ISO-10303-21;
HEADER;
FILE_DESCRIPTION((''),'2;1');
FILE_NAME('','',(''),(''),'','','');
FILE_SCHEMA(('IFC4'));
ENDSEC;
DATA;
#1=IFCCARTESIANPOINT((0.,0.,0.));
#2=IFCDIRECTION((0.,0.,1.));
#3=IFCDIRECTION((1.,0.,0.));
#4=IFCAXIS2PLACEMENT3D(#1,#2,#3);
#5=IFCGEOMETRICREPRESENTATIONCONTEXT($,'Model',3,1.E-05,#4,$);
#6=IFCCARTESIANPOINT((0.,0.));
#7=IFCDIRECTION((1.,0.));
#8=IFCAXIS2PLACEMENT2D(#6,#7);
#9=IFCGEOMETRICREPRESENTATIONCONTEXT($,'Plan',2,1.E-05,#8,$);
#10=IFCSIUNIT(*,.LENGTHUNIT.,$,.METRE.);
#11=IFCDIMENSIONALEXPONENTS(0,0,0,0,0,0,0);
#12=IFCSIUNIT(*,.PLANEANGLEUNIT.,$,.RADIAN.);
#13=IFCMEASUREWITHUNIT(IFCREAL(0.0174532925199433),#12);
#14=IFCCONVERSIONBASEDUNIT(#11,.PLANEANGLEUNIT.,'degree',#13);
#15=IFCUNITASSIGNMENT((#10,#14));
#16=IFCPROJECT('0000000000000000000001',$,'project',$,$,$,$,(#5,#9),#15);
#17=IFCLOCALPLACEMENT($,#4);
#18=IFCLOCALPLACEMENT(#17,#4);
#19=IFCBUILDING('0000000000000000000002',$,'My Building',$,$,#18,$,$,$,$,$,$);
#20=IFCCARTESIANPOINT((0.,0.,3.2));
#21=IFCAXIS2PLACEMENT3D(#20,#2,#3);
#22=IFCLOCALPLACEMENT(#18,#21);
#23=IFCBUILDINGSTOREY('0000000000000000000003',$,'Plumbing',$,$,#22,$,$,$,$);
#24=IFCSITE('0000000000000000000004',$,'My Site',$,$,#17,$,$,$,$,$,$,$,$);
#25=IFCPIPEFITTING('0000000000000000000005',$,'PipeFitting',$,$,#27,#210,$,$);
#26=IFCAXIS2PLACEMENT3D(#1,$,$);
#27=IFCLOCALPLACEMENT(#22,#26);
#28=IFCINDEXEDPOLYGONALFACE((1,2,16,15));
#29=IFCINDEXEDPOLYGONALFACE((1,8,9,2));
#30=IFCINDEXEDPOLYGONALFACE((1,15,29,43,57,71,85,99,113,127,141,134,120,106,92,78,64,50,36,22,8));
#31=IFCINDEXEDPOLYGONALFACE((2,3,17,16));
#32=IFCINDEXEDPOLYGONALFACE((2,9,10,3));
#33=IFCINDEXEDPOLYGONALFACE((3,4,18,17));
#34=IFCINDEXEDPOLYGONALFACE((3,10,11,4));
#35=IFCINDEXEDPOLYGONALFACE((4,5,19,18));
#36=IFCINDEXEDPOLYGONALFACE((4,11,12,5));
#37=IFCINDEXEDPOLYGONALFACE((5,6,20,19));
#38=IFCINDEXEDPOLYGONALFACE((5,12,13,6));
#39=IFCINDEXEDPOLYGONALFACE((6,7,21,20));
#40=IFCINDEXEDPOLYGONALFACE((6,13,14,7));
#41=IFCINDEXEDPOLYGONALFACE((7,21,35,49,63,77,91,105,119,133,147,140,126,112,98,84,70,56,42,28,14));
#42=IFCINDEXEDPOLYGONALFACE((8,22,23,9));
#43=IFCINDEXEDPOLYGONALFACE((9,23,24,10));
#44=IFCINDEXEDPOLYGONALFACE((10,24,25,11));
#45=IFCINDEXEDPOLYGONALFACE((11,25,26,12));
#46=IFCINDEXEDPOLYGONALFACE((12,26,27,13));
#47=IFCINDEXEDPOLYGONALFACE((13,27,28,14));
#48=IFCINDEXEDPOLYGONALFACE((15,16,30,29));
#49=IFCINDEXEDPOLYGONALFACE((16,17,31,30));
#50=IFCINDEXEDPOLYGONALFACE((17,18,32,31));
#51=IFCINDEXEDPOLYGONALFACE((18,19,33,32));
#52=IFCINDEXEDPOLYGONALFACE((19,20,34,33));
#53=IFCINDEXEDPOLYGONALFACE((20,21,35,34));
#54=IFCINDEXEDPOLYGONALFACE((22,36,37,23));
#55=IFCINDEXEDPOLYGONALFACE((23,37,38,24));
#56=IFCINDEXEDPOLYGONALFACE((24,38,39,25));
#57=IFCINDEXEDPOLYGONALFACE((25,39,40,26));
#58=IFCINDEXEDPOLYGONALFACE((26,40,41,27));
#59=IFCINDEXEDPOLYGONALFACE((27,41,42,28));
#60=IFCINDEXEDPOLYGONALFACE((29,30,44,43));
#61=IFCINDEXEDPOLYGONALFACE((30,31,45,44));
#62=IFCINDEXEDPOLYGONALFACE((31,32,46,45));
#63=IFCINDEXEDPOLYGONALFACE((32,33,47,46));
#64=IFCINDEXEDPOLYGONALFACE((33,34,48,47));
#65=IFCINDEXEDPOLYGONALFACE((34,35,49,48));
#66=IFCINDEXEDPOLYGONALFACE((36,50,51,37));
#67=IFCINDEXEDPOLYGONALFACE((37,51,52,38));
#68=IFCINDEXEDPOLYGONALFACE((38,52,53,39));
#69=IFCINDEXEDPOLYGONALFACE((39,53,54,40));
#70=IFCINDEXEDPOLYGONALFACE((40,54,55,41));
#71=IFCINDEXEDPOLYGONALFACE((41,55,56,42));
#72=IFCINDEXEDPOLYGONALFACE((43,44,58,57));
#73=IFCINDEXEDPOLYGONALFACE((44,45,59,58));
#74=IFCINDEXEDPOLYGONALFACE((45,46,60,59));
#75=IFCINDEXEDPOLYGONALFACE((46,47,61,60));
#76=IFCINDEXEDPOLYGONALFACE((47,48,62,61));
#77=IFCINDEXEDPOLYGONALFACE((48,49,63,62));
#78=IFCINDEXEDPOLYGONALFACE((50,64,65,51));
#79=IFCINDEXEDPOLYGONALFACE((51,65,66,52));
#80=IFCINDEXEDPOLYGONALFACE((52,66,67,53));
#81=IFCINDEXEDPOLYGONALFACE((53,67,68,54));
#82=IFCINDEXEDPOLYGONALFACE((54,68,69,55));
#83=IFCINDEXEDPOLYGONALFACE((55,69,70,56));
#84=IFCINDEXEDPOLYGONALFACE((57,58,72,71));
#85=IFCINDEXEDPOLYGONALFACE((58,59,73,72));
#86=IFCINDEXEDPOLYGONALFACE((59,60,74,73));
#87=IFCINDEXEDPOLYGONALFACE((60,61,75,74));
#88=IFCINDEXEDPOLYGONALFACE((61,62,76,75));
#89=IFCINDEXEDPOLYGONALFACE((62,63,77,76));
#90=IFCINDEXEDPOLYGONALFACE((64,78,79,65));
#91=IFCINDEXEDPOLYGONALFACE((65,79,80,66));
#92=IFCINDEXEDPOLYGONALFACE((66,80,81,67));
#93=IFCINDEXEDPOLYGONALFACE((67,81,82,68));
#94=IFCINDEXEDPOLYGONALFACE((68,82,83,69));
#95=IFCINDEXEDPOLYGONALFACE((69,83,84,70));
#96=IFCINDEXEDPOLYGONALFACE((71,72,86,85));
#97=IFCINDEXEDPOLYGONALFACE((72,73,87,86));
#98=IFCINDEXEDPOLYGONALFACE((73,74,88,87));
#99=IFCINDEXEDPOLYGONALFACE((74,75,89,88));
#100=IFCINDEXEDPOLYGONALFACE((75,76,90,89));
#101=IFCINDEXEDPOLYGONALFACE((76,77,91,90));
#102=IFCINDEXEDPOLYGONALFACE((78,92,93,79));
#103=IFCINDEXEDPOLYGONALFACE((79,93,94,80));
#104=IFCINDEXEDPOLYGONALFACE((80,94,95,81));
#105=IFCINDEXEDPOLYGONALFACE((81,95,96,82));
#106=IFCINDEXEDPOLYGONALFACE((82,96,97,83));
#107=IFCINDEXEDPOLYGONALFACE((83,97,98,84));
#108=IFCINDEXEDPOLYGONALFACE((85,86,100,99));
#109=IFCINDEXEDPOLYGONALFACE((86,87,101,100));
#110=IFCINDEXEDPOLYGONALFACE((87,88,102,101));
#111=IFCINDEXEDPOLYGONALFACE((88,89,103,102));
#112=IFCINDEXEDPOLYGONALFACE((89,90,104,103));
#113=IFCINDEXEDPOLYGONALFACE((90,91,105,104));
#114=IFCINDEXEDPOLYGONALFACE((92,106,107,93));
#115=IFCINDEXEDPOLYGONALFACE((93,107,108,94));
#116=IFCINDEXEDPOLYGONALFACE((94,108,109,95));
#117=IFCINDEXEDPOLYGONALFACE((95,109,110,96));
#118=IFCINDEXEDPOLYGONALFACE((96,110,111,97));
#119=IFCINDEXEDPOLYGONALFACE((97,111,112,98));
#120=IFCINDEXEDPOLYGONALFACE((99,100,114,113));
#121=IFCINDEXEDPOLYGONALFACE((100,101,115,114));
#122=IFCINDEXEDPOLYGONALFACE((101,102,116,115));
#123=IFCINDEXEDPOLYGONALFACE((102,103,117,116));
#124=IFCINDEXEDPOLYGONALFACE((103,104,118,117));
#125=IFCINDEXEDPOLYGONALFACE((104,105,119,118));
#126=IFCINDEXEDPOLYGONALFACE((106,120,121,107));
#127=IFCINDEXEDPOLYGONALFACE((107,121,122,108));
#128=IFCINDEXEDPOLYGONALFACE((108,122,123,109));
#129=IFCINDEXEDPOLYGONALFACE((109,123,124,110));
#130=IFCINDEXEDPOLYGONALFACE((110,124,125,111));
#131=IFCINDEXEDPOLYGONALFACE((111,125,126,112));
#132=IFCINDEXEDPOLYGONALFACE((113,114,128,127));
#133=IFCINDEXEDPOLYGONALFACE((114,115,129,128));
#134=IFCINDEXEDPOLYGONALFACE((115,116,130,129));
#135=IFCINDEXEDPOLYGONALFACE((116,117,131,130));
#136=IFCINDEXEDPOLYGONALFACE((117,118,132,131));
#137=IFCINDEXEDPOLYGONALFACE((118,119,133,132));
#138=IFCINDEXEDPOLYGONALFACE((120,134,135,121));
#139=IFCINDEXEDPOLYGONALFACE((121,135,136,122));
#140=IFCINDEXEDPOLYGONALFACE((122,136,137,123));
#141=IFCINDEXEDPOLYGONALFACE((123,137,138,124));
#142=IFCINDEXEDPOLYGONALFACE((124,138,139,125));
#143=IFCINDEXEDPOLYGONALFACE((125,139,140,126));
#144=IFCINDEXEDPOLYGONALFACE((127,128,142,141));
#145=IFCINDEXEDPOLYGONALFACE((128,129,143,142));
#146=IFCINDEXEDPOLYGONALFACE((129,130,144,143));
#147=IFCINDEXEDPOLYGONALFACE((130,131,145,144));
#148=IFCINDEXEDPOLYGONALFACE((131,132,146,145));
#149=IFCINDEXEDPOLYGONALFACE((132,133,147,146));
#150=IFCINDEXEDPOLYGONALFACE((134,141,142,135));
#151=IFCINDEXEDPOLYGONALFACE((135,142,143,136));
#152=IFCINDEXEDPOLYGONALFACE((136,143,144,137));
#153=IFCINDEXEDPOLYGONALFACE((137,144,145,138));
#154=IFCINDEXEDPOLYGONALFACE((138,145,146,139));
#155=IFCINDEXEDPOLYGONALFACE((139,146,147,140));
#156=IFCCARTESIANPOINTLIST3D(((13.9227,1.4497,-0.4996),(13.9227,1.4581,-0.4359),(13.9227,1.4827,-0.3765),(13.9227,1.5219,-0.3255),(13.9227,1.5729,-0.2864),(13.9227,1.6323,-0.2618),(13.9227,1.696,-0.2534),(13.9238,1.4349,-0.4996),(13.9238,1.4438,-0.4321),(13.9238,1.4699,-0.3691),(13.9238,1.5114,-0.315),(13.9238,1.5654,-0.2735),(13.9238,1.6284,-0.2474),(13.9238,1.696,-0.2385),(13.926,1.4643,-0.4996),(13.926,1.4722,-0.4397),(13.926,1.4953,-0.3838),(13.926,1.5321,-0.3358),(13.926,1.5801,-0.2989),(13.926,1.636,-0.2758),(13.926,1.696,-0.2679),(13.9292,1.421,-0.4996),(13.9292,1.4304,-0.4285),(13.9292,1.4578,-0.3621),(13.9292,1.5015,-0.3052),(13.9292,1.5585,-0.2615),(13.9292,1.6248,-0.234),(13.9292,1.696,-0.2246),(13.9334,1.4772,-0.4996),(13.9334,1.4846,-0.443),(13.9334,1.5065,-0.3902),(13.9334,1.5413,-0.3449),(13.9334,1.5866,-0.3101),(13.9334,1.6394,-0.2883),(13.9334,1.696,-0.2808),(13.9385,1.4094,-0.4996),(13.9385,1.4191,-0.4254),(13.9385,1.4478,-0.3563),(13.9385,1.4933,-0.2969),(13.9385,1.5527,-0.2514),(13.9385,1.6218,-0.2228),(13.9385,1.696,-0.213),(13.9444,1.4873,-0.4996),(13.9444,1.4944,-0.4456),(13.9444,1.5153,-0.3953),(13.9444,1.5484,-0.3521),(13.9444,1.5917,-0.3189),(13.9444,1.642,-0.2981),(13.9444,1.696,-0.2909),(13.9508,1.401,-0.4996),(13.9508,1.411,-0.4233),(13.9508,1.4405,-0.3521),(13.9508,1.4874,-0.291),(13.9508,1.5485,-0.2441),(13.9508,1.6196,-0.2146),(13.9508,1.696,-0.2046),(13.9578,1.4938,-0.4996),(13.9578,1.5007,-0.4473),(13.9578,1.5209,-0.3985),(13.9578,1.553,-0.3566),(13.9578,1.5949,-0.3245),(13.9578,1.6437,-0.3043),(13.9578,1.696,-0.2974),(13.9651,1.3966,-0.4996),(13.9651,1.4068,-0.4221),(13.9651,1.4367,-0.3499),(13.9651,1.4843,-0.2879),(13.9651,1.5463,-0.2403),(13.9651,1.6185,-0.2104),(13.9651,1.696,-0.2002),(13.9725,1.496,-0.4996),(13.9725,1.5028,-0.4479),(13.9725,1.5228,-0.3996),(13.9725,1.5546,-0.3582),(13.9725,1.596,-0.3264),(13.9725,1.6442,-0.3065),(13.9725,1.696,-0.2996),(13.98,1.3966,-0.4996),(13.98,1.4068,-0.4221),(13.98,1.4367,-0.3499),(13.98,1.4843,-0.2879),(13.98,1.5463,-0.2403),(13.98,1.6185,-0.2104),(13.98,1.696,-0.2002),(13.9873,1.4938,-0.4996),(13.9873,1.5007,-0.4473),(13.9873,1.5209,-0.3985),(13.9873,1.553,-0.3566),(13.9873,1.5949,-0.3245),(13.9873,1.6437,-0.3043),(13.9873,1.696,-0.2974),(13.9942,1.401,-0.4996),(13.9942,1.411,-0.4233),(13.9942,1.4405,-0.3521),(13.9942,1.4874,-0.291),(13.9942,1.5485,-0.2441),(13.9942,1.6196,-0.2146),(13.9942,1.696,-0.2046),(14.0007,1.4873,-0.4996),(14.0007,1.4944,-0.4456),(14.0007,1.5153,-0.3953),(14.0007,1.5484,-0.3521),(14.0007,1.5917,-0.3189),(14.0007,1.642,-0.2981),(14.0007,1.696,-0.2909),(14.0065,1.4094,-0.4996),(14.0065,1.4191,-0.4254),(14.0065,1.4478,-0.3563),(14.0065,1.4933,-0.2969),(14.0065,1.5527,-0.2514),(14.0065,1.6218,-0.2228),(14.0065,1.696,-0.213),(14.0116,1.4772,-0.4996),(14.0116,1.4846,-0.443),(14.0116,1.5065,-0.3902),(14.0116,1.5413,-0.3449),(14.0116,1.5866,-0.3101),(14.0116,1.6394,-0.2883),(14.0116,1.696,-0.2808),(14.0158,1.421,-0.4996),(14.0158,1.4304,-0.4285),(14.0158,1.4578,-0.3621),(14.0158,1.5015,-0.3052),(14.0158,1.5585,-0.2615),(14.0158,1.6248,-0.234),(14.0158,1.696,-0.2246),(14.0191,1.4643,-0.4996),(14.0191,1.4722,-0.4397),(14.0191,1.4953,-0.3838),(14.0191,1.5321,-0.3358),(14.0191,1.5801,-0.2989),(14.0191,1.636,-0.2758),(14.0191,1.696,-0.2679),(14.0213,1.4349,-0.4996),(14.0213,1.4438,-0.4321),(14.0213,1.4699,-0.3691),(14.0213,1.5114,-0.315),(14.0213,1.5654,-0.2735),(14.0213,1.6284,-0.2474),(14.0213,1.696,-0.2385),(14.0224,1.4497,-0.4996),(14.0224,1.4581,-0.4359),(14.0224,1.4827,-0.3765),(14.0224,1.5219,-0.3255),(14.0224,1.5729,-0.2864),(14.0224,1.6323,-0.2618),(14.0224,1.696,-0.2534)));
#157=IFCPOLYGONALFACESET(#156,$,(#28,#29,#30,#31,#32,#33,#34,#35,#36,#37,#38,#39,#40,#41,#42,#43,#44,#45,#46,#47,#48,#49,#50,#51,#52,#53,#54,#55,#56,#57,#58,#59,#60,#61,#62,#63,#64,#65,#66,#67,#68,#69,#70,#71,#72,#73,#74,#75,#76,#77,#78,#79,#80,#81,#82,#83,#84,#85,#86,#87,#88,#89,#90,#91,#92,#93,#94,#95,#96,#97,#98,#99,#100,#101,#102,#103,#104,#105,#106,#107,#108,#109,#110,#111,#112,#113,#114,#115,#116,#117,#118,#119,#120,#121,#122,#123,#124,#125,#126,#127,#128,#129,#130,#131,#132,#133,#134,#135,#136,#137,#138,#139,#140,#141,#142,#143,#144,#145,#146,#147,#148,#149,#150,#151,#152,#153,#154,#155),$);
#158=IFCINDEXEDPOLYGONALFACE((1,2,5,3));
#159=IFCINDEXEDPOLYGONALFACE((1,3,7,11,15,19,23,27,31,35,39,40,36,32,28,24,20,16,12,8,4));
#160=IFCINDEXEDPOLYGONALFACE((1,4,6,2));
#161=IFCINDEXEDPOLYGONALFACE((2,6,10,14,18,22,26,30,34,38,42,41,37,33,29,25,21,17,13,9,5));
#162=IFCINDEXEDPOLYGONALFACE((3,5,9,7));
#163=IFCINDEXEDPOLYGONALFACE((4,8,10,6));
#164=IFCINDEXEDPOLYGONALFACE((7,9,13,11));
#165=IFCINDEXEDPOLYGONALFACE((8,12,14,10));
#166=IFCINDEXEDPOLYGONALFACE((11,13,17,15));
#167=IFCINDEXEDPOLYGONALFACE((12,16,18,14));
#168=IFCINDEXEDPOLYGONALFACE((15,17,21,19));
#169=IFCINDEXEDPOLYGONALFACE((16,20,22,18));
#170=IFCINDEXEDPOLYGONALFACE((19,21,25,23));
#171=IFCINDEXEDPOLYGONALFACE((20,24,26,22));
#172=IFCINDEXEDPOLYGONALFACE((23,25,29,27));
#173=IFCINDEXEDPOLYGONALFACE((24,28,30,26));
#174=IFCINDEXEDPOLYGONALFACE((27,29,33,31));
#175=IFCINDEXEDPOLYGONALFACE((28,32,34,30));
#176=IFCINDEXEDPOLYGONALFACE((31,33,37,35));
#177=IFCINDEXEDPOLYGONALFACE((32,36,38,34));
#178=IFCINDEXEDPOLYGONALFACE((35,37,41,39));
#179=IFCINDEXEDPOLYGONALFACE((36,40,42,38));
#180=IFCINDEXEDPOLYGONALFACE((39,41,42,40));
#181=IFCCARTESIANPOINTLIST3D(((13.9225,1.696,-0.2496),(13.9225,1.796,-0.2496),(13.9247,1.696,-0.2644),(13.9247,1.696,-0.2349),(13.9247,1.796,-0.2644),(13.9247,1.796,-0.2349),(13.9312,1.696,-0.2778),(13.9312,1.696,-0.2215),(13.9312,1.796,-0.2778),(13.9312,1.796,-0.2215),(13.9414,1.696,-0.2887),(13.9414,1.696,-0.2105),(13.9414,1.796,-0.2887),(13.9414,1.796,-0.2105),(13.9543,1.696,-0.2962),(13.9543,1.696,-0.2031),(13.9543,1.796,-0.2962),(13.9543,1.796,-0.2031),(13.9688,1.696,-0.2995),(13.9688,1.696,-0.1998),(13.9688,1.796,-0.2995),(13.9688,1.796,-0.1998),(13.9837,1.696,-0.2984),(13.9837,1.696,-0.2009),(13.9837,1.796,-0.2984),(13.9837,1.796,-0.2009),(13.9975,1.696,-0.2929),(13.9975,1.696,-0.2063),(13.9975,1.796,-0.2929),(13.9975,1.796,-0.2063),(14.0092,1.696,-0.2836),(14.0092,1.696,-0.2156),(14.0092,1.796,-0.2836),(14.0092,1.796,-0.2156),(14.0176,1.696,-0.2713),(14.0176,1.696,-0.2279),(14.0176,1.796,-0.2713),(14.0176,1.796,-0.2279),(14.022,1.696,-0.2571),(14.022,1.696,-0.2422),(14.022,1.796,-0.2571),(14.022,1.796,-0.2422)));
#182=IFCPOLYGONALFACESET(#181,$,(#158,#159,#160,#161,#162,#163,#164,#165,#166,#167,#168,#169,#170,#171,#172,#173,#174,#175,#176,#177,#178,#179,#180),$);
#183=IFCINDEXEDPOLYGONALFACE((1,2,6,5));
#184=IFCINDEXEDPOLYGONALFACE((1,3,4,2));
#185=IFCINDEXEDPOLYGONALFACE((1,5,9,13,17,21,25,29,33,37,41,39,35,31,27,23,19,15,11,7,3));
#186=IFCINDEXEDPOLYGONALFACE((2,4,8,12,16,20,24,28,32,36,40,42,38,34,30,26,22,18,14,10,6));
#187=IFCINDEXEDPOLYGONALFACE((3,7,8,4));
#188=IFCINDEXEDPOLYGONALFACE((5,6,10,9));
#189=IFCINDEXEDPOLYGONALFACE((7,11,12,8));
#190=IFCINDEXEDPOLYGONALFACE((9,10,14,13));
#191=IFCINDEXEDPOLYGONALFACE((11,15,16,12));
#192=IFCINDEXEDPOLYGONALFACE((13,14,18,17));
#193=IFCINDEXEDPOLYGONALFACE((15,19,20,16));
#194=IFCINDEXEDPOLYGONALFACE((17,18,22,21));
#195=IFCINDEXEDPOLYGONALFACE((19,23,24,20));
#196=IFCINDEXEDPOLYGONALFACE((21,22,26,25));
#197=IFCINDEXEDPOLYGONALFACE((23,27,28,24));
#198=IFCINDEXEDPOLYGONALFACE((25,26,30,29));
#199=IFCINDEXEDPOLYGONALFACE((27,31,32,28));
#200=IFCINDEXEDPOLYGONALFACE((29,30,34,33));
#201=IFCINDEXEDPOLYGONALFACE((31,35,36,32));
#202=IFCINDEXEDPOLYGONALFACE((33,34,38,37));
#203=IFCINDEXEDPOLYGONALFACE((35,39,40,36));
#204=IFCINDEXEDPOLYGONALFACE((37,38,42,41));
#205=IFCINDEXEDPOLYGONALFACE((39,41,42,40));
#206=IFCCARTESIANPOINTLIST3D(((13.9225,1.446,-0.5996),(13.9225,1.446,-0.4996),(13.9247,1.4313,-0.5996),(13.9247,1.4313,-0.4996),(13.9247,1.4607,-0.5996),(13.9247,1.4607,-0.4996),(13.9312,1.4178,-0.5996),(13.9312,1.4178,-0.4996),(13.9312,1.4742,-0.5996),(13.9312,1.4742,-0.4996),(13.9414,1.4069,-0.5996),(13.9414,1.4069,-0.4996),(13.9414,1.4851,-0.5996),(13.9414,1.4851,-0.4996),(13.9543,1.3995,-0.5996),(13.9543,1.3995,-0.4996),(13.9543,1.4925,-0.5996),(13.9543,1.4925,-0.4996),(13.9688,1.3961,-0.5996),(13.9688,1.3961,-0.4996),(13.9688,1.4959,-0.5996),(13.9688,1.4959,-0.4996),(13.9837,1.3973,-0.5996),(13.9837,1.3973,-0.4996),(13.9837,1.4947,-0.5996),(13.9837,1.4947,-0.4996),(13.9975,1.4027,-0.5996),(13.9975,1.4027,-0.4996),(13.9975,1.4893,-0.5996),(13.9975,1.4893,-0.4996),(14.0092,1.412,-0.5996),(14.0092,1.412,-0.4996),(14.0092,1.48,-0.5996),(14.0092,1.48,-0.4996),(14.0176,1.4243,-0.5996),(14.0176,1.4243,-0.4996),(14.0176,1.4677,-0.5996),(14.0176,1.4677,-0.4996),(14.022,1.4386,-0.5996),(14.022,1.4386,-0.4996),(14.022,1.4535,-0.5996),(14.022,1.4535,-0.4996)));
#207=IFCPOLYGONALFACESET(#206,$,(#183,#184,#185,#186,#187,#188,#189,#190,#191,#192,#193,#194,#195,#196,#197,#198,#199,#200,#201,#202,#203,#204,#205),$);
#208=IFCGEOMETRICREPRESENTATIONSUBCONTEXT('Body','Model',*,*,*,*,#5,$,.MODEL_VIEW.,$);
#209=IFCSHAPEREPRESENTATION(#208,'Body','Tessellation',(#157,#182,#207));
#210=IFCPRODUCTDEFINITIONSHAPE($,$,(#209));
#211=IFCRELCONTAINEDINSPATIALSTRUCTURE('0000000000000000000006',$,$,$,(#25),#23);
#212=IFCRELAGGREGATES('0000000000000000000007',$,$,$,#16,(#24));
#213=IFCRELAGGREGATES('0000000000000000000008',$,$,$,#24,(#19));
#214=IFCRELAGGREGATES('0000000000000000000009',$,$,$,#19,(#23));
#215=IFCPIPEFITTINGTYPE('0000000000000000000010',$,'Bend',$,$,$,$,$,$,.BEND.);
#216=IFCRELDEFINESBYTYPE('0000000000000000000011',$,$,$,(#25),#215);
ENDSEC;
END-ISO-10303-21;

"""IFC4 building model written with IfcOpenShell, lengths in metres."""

from ifc_helpers import new_model, entity, si_unit, converted_unit, frame, origin_with_axes, origin_2d_with_axis, place, context, subcontext, project, spatial, circle, extrude, source, transform, mapped, type_object, type_shapes, element, save


model = new_model("IFC4")

# Units and contexts
model_context = context("Model", 3, precision=1e-05, world=origin_with_axes())
plan_context = context("Plan", 2, precision=1e-05, world=origin_2d_with_axis())
body_context = subcontext(model_context, "Body", "Model", "MODEL_VIEW")
ifc_project = project(units=[si_unit("LENGTHUNIT", "METRE"), converted_unit("PLANEANGLEUNIT", "degree", entity("IfcReal", 0.0174532925199433), si_unit("PLANEANGLEUNIT", "RADIAN"), dimensions=[0, 0, 0, 0, 0, 0, 0])], contexts=[model_context, plan_context])

# Site, building, storey
site_placement = place(None, origin_with_axes())
site = spatial("IfcSite", under=ifc_project, at=site_placement, Name="My Site")
building_placement = place(site_placement, origin_with_axes())
building = spatial("IfcBuilding", under=site, at=building_placement, Name="My Building")
storey_placement = place(building_placement, frame((0.0, 0.0, 3.2), z_axis=(0.0, 0.0, 1.0), x_axis=(1.0, 0.0, 0.0)))
storey = spatial("IfcBuildingStorey", under=building, at=storey_placement, Name="Plumbing")

# Pipe fitting
pipe_fitting_type = type_object("IfcPipeFittingType", Name="Bend", PredefinedType="BEND")
shared_shape = source(origin_with_axes(), body_context, "Body", "SolidModel", [
    entity("IfcSweptDiskSolid", entity("IfcIndexedPolyCurve", entity("IfcCartesianPointList3D", [[0.0, 0.0, -0.1], [0.0, -0.0732, -0.2768], [0.0, -0.25, -0.35]]), [entity("IfcArcIndex", [1, 2, 3])]), 0.05),
    extrude(circle(Radius=0.05), origin_with_axes(), (0.0, 0.0, -1.0), 0.1),
    extrude(circle(Radius=0.05), frame((0.0, -0.25, -0.35), z_axis=(0.0, -1.0, 0.0), x_axis=(1.0, 0.0, 0.0)), (0.0, 0.0, 1.0), 0.1),
])
type_shapes(pipe_fitting_type, [shared_shape])
for number, where, z_axis, x_axis, name in (
    (1, (13.9725, 1.796, -0.2496), (0.0, 1.0, 0.0), (-1.0, 0.0, 0.0), "PipeFitting"),
):
    element("IfcPipeFitting", number, at=place(storey_placement, frame(where, z_axis=z_axis, x_axis=x_axis)), inside=storey, type_object=pipe_fitting_type, Name=name, context=body_context, shape_type="MappedRepresentation", body=[
        mapped(shared_shape, transform((0.0, 0.0, 0.0), x_axis=(1.0, 0.0, 0.0), y_axis=(0.0, 1.0, 0.0), z_axis=(0.0, 0.0, 1.0), scale=1.0)),
    ])

save(model, "model.ifc")
